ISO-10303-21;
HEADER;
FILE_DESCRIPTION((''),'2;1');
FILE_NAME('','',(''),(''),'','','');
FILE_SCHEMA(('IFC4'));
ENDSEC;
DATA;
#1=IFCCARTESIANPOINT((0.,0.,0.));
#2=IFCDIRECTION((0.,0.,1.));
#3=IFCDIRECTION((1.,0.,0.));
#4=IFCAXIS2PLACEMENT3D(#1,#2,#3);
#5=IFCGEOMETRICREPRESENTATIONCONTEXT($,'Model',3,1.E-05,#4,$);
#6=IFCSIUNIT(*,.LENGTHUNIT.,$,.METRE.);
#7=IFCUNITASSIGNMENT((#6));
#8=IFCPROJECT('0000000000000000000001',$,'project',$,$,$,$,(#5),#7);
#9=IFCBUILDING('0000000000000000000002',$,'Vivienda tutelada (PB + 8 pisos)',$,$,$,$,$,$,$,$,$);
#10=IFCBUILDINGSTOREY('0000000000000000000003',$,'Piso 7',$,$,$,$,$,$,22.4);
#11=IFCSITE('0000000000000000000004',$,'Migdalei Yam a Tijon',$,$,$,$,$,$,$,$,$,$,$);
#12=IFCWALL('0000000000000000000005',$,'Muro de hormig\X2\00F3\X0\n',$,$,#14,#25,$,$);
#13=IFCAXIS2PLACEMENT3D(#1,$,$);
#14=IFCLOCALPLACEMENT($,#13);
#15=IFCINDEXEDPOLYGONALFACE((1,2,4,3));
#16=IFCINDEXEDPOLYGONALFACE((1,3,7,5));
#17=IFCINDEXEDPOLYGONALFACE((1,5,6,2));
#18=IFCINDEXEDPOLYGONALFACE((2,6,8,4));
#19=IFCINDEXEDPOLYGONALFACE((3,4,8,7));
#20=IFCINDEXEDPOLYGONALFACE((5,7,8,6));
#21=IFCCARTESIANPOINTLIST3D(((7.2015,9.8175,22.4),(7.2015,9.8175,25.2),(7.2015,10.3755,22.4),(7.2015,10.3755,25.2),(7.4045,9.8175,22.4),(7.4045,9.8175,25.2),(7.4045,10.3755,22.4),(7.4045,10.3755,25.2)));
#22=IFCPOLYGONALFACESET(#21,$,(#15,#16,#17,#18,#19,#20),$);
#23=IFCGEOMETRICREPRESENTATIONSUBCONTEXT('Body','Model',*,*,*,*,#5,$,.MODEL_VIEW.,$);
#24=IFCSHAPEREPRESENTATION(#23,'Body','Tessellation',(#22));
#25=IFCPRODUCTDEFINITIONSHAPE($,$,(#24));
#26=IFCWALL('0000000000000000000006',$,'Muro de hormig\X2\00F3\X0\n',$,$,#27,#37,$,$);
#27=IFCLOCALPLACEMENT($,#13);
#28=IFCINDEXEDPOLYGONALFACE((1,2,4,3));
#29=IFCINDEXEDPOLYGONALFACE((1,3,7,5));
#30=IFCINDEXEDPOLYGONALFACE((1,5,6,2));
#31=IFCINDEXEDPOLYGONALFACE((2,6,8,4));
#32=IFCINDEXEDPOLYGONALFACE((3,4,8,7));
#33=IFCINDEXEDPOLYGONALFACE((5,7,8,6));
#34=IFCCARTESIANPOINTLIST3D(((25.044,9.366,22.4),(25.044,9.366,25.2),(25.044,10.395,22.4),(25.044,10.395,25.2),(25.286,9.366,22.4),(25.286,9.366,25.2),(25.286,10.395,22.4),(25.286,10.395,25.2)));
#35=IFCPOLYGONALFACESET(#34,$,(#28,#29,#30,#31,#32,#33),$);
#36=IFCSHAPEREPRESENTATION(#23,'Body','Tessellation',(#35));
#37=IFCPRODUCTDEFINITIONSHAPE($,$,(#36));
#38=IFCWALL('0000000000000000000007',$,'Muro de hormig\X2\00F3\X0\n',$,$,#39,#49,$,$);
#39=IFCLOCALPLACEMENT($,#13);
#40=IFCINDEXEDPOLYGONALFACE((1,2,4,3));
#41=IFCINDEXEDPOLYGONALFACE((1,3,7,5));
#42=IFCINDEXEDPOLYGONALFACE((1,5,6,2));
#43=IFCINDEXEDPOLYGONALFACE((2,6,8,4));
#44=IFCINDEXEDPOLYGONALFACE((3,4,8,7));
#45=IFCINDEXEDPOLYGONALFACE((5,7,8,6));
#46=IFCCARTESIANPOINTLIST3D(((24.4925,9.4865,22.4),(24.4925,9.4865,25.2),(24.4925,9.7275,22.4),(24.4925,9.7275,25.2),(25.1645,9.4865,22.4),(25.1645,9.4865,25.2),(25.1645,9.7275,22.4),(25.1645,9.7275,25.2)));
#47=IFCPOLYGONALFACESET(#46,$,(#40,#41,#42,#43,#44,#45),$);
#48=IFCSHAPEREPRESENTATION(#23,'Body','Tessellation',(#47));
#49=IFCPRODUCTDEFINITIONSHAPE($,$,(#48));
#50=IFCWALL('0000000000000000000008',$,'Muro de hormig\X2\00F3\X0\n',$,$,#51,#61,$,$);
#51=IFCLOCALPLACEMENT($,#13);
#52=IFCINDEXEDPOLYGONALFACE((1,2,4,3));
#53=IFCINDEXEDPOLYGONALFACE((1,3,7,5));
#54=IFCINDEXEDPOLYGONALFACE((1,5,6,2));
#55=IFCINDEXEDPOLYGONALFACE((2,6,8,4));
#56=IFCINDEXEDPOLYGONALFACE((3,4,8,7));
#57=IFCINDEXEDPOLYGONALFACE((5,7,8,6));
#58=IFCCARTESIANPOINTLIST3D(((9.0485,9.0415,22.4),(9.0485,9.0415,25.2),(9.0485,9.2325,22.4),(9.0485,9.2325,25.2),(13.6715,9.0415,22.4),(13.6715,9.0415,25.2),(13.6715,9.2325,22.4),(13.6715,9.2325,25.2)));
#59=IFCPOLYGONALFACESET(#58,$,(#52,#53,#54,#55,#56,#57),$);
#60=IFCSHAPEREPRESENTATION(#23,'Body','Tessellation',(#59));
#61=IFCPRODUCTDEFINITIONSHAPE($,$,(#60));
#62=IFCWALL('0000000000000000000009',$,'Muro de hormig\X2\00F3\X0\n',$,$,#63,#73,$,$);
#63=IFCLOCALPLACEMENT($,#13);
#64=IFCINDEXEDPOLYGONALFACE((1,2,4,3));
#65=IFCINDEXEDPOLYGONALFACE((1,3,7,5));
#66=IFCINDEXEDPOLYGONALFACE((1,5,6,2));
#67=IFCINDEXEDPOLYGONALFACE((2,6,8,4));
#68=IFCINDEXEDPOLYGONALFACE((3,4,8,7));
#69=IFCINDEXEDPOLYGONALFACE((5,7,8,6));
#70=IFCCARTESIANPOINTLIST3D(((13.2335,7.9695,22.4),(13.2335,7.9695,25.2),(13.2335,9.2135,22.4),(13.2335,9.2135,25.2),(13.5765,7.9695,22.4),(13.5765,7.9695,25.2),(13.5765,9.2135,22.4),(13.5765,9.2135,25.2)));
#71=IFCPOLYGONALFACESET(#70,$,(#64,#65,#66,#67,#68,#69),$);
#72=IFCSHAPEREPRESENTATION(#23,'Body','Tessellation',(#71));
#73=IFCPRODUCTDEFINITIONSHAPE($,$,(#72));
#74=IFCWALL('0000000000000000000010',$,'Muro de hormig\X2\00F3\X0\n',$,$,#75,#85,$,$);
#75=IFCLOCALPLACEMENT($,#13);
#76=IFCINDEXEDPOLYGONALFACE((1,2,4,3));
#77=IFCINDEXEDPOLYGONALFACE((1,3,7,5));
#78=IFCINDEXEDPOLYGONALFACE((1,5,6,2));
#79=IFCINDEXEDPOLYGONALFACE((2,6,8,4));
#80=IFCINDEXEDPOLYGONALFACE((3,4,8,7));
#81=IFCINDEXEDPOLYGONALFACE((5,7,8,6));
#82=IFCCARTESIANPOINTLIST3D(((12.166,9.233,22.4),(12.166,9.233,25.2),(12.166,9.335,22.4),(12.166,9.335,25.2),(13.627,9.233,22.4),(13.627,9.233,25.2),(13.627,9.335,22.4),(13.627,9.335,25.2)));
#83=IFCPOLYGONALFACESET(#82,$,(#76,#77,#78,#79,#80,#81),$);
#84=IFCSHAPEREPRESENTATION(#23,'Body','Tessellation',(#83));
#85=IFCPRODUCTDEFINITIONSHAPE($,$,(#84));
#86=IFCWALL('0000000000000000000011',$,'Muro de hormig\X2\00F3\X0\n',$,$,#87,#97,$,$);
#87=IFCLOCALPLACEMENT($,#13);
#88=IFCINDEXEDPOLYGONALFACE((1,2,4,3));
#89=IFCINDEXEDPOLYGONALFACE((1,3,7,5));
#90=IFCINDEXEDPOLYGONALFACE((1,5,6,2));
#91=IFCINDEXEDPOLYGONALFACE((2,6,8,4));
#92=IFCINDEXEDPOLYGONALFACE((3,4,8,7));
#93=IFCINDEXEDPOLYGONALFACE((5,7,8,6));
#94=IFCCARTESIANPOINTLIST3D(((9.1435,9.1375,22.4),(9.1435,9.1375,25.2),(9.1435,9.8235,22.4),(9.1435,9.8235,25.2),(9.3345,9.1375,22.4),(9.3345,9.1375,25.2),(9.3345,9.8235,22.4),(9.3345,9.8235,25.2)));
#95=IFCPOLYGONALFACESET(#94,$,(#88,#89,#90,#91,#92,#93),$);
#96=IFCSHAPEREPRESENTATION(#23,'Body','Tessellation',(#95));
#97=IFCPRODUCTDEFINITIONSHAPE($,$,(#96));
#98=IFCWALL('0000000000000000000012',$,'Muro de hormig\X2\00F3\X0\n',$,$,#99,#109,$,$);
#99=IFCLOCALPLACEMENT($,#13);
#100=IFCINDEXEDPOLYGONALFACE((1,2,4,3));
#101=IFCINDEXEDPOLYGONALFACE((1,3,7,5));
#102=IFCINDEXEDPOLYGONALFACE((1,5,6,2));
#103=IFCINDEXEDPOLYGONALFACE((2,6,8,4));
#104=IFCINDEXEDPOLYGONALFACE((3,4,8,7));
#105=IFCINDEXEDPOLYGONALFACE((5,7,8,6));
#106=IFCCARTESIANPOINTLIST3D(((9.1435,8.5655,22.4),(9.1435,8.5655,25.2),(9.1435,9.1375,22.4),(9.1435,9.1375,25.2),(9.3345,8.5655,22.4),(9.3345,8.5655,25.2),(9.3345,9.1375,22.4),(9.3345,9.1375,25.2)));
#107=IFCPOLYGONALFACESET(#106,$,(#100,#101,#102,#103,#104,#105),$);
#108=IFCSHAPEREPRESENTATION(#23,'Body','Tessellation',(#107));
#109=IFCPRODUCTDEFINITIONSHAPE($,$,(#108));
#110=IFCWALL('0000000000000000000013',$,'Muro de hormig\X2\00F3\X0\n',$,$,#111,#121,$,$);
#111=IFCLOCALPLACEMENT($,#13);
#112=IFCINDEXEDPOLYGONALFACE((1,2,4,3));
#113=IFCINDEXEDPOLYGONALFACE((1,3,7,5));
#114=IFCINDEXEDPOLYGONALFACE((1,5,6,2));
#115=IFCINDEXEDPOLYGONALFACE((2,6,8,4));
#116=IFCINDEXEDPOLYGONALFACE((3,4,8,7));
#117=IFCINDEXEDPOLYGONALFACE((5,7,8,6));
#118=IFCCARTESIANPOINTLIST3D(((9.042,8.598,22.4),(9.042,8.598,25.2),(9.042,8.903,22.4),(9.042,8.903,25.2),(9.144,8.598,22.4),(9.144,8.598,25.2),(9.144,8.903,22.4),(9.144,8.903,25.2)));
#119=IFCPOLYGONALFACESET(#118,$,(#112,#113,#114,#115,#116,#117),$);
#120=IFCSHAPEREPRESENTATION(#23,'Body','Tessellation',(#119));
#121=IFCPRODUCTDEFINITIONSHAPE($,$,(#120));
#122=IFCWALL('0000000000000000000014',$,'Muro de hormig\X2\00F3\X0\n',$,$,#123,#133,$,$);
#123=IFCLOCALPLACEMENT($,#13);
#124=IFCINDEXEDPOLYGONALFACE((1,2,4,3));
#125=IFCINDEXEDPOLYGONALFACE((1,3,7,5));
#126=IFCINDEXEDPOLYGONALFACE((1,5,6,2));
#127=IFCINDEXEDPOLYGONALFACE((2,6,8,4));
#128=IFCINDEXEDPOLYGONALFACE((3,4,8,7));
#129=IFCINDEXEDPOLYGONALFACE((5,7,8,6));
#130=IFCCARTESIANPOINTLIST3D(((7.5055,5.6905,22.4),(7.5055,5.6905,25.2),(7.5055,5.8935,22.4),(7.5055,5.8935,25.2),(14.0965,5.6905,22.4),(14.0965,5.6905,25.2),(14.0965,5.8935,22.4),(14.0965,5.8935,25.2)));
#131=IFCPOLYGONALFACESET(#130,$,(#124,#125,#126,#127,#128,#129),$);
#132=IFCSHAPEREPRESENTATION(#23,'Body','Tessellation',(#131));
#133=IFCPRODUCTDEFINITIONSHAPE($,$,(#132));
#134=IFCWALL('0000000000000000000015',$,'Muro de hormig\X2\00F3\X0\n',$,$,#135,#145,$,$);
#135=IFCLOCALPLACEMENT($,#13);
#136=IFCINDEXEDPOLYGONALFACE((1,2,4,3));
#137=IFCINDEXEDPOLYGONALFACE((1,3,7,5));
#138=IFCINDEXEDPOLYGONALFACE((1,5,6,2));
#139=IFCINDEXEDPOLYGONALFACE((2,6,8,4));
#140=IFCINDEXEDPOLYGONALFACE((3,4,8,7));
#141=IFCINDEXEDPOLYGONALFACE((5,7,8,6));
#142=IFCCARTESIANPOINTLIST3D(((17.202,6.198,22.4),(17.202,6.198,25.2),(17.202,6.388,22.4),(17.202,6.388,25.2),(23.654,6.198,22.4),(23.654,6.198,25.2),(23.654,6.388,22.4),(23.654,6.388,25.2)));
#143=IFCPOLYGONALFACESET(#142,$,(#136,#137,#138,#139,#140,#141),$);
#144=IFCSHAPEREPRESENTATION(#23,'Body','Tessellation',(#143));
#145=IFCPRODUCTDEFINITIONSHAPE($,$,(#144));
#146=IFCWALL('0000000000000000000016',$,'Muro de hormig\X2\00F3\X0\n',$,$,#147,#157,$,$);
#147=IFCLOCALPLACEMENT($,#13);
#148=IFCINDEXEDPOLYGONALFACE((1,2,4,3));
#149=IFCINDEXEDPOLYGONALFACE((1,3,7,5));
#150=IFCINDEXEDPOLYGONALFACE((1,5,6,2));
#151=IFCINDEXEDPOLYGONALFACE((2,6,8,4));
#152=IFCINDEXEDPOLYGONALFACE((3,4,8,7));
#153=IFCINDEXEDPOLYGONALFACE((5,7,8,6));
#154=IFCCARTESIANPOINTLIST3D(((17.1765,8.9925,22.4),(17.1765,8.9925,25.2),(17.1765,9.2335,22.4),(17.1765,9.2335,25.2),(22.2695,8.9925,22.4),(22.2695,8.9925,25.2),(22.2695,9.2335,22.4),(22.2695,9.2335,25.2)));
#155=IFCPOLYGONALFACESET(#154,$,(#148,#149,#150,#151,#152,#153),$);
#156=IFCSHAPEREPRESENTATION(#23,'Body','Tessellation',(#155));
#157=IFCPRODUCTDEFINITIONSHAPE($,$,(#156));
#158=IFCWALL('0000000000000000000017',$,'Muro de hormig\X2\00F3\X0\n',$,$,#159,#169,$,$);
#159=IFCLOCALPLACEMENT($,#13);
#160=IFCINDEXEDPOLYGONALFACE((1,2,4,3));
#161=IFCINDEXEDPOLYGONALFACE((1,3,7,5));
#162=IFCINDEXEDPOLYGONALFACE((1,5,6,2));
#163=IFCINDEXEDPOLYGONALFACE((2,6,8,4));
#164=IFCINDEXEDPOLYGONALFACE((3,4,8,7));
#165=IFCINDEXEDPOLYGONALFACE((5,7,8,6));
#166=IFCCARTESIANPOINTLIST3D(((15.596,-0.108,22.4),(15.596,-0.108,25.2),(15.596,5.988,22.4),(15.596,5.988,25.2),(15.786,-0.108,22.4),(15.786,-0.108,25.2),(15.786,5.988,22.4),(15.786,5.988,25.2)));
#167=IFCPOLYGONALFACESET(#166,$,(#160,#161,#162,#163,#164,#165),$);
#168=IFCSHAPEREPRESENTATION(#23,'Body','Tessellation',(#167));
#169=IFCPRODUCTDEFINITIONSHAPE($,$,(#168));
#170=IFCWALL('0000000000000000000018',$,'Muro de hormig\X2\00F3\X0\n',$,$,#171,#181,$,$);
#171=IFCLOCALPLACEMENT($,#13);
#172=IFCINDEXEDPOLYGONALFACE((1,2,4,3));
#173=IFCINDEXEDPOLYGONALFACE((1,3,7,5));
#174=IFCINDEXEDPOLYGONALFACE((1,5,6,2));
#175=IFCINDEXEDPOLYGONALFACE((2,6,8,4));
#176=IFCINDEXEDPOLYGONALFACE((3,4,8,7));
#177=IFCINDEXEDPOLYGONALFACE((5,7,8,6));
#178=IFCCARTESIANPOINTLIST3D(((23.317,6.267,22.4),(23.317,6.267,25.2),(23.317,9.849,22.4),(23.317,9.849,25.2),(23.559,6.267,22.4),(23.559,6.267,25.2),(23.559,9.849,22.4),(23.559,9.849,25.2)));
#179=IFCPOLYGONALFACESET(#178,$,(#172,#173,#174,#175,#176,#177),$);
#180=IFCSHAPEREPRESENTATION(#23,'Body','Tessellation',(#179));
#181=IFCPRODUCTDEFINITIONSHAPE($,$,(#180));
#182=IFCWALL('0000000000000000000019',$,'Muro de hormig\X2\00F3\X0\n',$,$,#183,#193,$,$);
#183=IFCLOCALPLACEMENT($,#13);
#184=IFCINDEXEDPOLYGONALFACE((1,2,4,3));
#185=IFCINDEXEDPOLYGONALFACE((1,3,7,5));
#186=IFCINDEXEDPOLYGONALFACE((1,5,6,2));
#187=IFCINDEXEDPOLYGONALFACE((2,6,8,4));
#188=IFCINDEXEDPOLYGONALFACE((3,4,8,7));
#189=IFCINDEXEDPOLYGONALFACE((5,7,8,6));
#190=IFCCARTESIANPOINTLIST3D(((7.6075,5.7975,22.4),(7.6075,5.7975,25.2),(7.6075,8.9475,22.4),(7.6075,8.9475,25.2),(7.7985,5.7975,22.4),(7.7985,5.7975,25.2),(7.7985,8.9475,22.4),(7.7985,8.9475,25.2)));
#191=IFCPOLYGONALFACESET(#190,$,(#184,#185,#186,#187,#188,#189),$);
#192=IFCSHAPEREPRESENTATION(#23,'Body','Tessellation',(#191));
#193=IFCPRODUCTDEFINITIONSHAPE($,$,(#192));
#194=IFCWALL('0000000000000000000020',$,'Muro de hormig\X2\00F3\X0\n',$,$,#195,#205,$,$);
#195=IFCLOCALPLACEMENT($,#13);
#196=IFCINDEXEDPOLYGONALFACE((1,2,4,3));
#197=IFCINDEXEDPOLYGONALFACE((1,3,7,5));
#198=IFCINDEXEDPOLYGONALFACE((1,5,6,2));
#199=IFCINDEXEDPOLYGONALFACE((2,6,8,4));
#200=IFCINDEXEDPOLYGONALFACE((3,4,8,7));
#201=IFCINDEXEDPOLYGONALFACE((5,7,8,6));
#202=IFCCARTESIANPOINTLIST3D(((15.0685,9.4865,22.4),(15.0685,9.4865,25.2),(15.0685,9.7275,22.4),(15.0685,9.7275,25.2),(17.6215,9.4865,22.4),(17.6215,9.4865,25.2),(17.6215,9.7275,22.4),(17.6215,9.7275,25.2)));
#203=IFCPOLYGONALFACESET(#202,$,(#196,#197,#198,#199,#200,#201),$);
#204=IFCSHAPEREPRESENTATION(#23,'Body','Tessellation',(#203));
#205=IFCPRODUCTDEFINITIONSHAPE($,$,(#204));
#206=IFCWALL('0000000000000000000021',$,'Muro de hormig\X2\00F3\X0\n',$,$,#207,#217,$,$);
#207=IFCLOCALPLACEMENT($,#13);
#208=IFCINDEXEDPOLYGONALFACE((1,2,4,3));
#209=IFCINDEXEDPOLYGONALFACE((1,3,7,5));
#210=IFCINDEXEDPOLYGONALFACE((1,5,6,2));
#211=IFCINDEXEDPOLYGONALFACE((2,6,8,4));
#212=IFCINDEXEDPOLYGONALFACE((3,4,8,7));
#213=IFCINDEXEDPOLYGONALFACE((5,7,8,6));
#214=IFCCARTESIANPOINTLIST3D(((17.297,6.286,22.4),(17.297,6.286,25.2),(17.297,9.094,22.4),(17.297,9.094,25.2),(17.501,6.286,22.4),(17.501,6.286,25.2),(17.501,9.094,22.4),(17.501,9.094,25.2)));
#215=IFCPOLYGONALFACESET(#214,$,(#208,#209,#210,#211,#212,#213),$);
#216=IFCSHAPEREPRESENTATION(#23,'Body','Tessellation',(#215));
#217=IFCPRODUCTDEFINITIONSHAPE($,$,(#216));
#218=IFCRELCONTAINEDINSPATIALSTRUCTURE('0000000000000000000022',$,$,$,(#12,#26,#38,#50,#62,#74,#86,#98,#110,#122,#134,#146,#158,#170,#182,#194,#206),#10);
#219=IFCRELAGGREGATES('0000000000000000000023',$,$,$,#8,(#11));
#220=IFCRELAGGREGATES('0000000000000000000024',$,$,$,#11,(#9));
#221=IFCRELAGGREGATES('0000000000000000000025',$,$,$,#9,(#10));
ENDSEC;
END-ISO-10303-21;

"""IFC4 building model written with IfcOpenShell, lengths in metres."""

from ifc_helpers import new_model, si_unit, frame, origin_with_axes, context, subcontext, project, spatial, line, indexed_curve, outline, extrude, element, save


model = new_model("IFC4")

# Units and contexts
model_context = context("Model", 3, precision=1e-05, world=origin_with_axes())
body_context = subcontext(model_context, "Body", "Model", "MODEL_VIEW")
ifc_project = project(units=[si_unit("LENGTHUNIT", "METRE")], contexts=[model_context])

# Site, building, storey
site = spatial("IfcSite", under=ifc_project, Name="Migdalei Yam a Tijon")
building = spatial("IfcBuilding", under=site, Name="Vivienda tutelada (PB + 8 pisos)")
storey = spatial("IfcBuildingStorey", under=building, Name="Piso 7", Elevation=22.4)

# Walls
element("IfcWall", 1, inside=storey, Name="Muro de hormigón", context=body_context, shape_type="SweptSolid", body=[
    extrude(outline(indexed_curve([(0.0, 0.0), (0.203, 0.0), (0.203, 0.558), (0.0, 0.558)], segments=[line(1, 2, 3, 4, 1)])), frame((7.2015, 9.8175, 22.4), z_axis=(0.0, 0.0, 1.0), x_axis=(1.0, 0.0, 0.0)), (0.0, 0.0, 1.0), 2.8),
])
element("IfcWall", 2, inside=storey, Name="Muro de hormigón", context=body_context, shape_type="SweptSolid", body=[
    extrude(outline(indexed_curve([(0.0, 0.0), (0.242, 0.0), (0.242, 1.029), (0.0, 1.029)], segments=[line(1, 2, 3, 4, 1)])), frame((25.044, 9.366, 22.4), z_axis=(0.0, 0.0, 1.0), x_axis=(1.0, 0.0, 0.0)), (0.0, 0.0, 1.0), 2.8),
])
element("IfcWall", 3, inside=storey, Name="Muro de hormigón", context=body_context, shape_type="SweptSolid", body=[
    extrude(outline(indexed_curve([(0.0, 0.0), (0.672, 0.0), (0.672, 0.241), (0.0, 0.241)], segments=[line(1, 2, 3, 4, 1)])), frame((24.4925, 9.4865, 22.4), z_axis=(0.0, 0.0, 1.0), x_axis=(1.0, 0.0, 0.0)), (0.0, 0.0, 1.0), 2.8),
])
element("IfcWall", 4, inside=storey, Name="Muro de hormigón", context=body_context, shape_type="SweptSolid", body=[
    extrude(outline(indexed_curve([(0.0, 0.0), (4.623, 0.0), (4.623, 0.191), (0.0, 0.191)], segments=[line(1, 2, 3, 4, 1)])), frame((9.0485, 9.0415, 22.4), z_axis=(0.0, 0.0, 1.0), x_axis=(1.0, 0.0, 0.0)), (0.0, 0.0, 1.0), 2.8),
])
element("IfcWall", 5, inside=storey, Name="Muro de hormigón", context=body_context, shape_type="SweptSolid", body=[
    extrude(outline(indexed_curve([(0.0, 0.0), (0.343, 0.0), (0.343, 1.244), (0.0, 1.244)], segments=[line(1, 2, 3, 4, 1)])), frame((13.2335, 7.9695, 22.4), z_axis=(0.0, 0.0, 1.0), x_axis=(1.0, 0.0, 0.0)), (0.0, 0.0, 1.0), 2.8),
])
element("IfcWall", 6, inside=storey, Name="Muro de hormigón", context=body_context, shape_type="SweptSolid", body=[
    extrude(outline(indexed_curve([(0.0, 0.0), (1.461, 0.0), (1.461, 0.102), (0.0, 0.102)], segments=[line(1, 2, 3, 4, 1)])), frame((12.166, 9.233, 22.4), z_axis=(0.0, 0.0, 1.0), x_axis=(1.0, 0.0, 0.0)), (0.0, 0.0, 1.0), 2.8),
])
element("IfcWall", 7, inside=storey, Name="Muro de hormigón", context=body_context, shape_type="SweptSolid", body=[
    extrude(outline(indexed_curve([(0.0, 0.0), (0.191, 0.0), (0.191, 0.686), (0.0, 0.686)], segments=[line(1, 2, 3, 4, 1)])), frame((9.1435, 9.1375, 22.4), z_axis=(0.0, 0.0, 1.0), x_axis=(1.0, 0.0, 0.0)), (0.0, 0.0, 1.0), 2.8),
])
element("IfcWall", 8, inside=storey, Name="Muro de hormigón", context=body_context, shape_type="SweptSolid", body=[
    extrude(outline(indexed_curve([(0.0, 0.0), (0.191, 0.0), (0.191, 0.572), (0.0, 0.572)], segments=[line(1, 2, 3, 4, 1)])), frame((9.1435, 8.5655, 22.4), z_axis=(0.0, 0.0, 1.0), x_axis=(1.0, 0.0, 0.0)), (0.0, 0.0, 1.0), 2.8),
])
element("IfcWall", 9, inside=storey, Name="Muro de hormigón", context=body_context, shape_type="SweptSolid", body=[
    extrude(outline(indexed_curve([(0.0, 0.0), (0.102, 0.0), (0.102, 0.305), (0.0, 0.305)], segments=[line(1, 2, 3, 4, 1)])), frame((9.042, 8.598, 22.4), z_axis=(0.0, 0.0, 1.0), x_axis=(1.0, 0.0, 0.0)), (0.0, 0.0, 1.0), 2.8),
])
element("IfcWall", 10, inside=storey, Name="Muro de hormigón", context=body_context, shape_type="SweptSolid", body=[
    extrude(outline(indexed_curve([(0.0, 0.0), (6.591, 0.0), (6.591, 0.203), (0.0, 0.203)], segments=[line(1, 2, 3, 4, 1)])), frame((7.5055, 5.6905, 22.4), z_axis=(0.0, 0.0, 1.0), x_axis=(1.0, 0.0, 0.0)), (0.0, 0.0, 1.0), 2.8),
])
element("IfcWall", 11, inside=storey, Name="Muro de hormigón", context=body_context, shape_type="SweptSolid", body=[
    extrude(outline(indexed_curve([(0.0, 0.0), (6.452, 0.0), (6.452, 0.19), (0.0, 0.19)], segments=[line(1, 2, 3, 4, 1)])), frame((17.202, 6.198, 22.4), z_axis=(0.0, 0.0, 1.0), x_axis=(1.0, 0.0, 0.0)), (0.0, 0.0, 1.0), 2.8),
])
element("IfcWall", 12, inside=storey, Name="Muro de hormigón", context=body_context, shape_type="SweptSolid", body=[
    extrude(outline(indexed_curve([(0.0, 0.0), (5.093, 0.0), (5.093, 0.241), (0.0, 0.241)], segments=[line(1, 2, 3, 4, 1)])), frame((17.1765, 8.9925, 22.4), z_axis=(0.0, 0.0, 1.0), x_axis=(1.0, 0.0, 0.0)), (0.0, 0.0, 1.0), 2.8),
])
element("IfcWall", 13, inside=storey, Name="Muro de hormigón", context=body_context, shape_type="SweptSolid", body=[
    extrude(outline(indexed_curve([(0.0, 0.0), (0.19, 0.0), (0.19, 6.096), (0.0, 6.096)], segments=[line(1, 2, 3, 4, 1)])), frame((15.596, -0.108, 22.4), z_axis=(0.0, 0.0, 1.0), x_axis=(1.0, 0.0, 0.0)), (0.0, 0.0, 1.0), 2.8),
])
element("IfcWall", 14, inside=storey, Name="Muro de hormigón", context=body_context, shape_type="SweptSolid", body=[
    extrude(outline(indexed_curve([(0.0, 0.0), (0.242, 0.0), (0.242, 3.582), (0.0, 3.582)], segments=[line(1, 2, 3, 4, 1)])), frame((23.317, 6.267, 22.4), z_axis=(0.0, 0.0, 1.0), x_axis=(1.0, 0.0, 0.0)), (0.0, 0.0, 1.0), 2.8),
])
element("IfcWall", 15, inside=storey, Name="Muro de hormigón", context=body_context, shape_type="SweptSolid", body=[
    extrude(outline(indexed_curve([(0.0, 0.0), (0.191, 0.0), (0.191, 3.15), (0.0, 3.15)], segments=[line(1, 2, 3, 4, 1)])), frame((7.6075, 5.7975, 22.4), z_axis=(0.0, 0.0, 1.0), x_axis=(1.0, 0.0, 0.0)), (0.0, 0.0, 1.0), 2.8),
])
element("IfcWall", 16, inside=storey, Name="Muro de hormigón", context=body_context, shape_type="SweptSolid", body=[
    extrude(outline(indexed_curve([(0.0, 0.0), (2.553, 0.0), (2.553, 0.241), (0.0, 0.241)], segments=[line(1, 2, 3, 4, 1)])), frame((15.0685, 9.4865, 22.4), z_axis=(0.0, 0.0, 1.0), x_axis=(1.0, 0.0, 0.0)), (0.0, 0.0, 1.0), 2.8),
])
element("IfcWall", 17, inside=storey, Name="Muro de hormigón", context=body_context, shape_type="SweptSolid", body=[
    extrude(outline(indexed_curve([(0.0, 0.0), (0.204, 0.0), (0.204, 2.808), (0.0, 2.808)], segments=[line(1, 2, 3, 4, 1)])), frame((17.297, 6.286, 22.4), z_axis=(0.0, 0.0, 1.0), x_axis=(1.0, 0.0, 0.0)), (0.0, 0.0, 1.0), 2.8),
])

save(model, "model.ifc")
